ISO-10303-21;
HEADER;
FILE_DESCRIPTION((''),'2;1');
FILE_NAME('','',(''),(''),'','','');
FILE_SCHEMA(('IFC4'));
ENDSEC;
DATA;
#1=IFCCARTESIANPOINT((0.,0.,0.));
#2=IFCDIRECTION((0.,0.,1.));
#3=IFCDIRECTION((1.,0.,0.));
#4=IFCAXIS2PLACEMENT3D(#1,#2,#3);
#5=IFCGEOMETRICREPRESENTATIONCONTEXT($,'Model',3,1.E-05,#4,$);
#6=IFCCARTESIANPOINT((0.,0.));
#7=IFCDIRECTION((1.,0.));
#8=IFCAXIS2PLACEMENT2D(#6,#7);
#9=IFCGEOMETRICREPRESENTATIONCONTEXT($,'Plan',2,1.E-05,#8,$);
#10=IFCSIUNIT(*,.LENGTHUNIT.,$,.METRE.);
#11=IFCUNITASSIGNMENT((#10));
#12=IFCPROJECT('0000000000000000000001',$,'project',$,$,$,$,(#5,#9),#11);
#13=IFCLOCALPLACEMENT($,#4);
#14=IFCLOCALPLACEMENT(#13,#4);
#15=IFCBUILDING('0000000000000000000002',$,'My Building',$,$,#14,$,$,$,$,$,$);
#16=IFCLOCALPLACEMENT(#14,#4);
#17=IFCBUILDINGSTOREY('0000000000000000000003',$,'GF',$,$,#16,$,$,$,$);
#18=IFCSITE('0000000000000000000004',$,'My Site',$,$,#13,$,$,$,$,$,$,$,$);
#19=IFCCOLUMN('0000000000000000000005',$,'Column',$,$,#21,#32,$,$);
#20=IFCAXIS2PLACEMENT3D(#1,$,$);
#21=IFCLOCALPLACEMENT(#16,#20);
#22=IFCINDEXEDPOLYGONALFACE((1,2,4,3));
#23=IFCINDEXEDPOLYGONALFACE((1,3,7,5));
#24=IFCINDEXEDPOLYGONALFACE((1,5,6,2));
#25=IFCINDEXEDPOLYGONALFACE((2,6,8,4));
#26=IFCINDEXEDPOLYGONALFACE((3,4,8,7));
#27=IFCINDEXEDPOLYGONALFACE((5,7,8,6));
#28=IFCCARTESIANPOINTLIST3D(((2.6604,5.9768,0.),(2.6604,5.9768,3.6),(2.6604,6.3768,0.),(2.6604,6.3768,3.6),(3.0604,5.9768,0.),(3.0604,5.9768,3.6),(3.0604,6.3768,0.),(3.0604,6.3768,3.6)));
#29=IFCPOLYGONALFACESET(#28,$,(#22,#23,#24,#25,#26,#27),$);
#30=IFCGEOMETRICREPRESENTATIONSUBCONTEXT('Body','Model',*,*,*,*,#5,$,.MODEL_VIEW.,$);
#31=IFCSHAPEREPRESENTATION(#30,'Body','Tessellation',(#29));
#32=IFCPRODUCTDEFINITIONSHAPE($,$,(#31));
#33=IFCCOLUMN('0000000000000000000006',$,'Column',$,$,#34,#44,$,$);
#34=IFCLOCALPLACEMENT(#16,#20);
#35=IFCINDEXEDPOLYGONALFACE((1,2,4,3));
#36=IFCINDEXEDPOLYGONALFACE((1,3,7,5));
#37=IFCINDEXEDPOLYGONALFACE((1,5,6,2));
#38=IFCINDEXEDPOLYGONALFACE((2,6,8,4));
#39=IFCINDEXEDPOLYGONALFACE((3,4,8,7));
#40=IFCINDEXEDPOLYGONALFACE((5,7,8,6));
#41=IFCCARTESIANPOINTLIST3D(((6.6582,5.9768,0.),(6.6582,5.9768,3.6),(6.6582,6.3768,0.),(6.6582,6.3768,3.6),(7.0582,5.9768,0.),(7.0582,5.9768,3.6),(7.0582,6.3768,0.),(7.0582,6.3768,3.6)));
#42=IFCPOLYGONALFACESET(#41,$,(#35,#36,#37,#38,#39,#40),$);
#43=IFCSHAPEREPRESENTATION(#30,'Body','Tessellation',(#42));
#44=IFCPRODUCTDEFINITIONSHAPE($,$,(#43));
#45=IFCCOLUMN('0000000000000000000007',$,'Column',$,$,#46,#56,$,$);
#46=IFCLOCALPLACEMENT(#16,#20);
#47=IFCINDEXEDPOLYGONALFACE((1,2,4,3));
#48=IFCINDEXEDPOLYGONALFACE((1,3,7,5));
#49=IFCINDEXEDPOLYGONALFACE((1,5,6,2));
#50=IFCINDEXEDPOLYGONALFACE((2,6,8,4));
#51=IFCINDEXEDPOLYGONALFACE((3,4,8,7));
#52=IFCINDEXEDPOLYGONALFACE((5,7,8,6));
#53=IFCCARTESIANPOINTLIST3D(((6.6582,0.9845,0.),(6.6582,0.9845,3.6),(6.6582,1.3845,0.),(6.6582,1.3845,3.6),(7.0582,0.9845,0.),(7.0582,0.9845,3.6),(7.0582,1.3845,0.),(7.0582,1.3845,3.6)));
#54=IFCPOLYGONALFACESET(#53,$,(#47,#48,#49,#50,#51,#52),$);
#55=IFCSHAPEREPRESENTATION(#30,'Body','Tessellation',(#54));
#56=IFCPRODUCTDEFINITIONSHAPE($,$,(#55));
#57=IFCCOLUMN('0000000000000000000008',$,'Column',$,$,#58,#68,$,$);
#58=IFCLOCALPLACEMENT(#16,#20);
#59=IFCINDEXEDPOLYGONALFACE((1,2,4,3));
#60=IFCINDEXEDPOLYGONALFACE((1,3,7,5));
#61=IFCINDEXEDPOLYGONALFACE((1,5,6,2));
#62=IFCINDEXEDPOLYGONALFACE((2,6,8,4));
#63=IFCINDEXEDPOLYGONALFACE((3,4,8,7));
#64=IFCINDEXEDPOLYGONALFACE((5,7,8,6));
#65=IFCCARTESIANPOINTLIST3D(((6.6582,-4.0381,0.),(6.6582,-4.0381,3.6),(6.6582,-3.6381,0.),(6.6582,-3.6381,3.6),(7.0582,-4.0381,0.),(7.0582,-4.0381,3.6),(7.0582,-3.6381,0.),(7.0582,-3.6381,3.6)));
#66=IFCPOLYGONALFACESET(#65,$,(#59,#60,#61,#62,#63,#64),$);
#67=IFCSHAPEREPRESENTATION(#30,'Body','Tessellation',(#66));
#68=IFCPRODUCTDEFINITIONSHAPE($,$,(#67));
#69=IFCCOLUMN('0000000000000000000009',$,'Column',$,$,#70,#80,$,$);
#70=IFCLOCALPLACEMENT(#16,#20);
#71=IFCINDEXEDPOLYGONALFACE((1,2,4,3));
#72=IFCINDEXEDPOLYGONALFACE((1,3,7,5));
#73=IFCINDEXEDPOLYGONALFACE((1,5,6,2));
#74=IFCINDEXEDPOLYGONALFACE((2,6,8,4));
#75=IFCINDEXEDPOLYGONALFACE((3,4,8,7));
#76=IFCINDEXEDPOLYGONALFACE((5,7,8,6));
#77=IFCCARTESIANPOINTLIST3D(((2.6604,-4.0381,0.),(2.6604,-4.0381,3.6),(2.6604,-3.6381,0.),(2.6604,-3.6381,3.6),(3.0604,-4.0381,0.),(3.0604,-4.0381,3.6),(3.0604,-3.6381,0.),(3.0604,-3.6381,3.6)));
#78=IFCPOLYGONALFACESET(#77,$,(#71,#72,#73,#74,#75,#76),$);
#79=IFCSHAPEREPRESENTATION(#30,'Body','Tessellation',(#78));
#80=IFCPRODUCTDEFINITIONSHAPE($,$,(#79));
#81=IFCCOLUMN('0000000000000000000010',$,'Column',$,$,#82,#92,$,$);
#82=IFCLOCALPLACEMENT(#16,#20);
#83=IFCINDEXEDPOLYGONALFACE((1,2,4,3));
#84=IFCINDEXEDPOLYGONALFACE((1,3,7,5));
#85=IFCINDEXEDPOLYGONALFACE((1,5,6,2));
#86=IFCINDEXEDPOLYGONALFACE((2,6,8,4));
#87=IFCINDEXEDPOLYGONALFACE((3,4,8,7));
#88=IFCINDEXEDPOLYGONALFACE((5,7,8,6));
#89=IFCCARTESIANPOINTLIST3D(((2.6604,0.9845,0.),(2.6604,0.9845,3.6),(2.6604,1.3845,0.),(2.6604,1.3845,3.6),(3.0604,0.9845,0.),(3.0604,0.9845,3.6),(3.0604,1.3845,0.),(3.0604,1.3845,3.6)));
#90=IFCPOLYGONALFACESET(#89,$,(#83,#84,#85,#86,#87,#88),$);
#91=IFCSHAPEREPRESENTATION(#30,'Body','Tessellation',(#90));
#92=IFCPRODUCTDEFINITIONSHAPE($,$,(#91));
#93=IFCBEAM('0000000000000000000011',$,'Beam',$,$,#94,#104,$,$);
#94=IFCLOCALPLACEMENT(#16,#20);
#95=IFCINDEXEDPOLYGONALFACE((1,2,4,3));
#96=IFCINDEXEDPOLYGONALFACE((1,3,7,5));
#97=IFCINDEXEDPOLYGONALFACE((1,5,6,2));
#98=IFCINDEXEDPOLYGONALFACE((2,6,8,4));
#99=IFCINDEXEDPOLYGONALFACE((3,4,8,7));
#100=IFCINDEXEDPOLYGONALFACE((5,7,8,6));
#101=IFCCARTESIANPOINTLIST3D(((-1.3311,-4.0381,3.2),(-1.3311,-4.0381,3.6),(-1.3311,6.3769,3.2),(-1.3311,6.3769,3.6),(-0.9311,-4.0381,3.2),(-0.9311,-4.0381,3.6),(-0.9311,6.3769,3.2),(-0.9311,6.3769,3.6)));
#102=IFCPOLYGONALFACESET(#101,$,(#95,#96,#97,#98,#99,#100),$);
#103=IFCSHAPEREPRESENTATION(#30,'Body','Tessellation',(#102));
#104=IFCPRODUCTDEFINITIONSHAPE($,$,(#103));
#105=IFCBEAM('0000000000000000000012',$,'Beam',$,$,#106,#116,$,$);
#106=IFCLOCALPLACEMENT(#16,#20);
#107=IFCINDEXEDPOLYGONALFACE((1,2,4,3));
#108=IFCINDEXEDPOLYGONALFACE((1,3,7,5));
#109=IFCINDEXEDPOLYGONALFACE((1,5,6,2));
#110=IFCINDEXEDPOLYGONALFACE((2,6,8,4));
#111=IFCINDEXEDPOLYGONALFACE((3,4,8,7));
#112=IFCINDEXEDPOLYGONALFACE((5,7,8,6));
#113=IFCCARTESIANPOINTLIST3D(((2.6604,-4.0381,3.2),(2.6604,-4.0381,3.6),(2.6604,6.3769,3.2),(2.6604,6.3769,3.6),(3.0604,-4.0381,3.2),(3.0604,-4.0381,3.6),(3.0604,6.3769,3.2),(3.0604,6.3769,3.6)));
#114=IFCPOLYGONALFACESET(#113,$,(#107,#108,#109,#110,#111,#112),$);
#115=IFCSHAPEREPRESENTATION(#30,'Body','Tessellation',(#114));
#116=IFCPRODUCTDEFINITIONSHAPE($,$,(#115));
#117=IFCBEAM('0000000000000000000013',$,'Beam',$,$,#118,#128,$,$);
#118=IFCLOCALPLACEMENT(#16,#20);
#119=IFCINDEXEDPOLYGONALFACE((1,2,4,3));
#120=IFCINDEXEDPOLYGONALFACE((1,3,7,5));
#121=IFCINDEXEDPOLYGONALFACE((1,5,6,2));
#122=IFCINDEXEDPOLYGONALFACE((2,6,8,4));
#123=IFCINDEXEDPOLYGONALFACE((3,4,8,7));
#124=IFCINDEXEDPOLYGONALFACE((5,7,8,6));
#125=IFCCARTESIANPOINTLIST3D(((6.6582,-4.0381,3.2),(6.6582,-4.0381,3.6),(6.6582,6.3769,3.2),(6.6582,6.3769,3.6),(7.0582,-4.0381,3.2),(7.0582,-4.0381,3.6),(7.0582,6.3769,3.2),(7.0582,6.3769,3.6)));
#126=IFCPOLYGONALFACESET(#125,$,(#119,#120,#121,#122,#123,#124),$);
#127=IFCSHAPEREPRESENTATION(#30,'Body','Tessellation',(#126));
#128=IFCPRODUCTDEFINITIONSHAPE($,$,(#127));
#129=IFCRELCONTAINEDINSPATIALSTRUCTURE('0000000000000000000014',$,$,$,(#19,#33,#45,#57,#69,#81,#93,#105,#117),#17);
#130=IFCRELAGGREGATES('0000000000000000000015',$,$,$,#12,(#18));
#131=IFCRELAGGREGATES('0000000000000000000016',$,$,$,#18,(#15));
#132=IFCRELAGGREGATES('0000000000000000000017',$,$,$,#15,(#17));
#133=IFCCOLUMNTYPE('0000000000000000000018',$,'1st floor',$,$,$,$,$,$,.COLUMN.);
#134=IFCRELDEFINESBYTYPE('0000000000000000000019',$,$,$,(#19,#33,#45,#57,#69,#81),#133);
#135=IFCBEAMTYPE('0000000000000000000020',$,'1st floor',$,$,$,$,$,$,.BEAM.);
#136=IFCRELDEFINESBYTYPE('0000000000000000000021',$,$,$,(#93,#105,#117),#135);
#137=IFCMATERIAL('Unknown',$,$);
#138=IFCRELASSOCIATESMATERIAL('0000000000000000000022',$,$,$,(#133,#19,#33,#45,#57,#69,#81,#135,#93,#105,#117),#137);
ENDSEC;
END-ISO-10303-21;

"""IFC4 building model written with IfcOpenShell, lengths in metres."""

from ifc_helpers import new_model, si_unit, frame, origin_with_axes, origin_2d_with_axis, place, context, subcontext, project, spatial, rectangle, extrude, material, material_profile, profile_set, profile_usage, type_object, element, save


model = new_model("IFC4")

# Units and contexts
model_context = context("Model", 3, precision=1e-05, world=origin_with_axes())
plan_context = context("Plan", 2, precision=1e-05, world=origin_2d_with_axis())
body_context_1 = subcontext(model_context, "Body", "Model", "MODEL_VIEW")
ifc_project = project(units=[si_unit("LENGTHUNIT", "METRE")], contexts=[model_context, plan_context])

# Site, building, storey
site_placement = place(None, origin_with_axes())
site = spatial("IfcSite", under=ifc_project, at=site_placement, Name="My Site")
building_placement = place(site_placement, origin_with_axes())
building = spatial("IfcBuilding", under=site, at=building_placement, Name="My Building")
storey_placement = place(building_placement, origin_with_axes())
storey = spatial("IfcBuildingStorey", under=building, at=storey_placement, Name="GF")

# Columns
ifc_material = material(Name="Unknown")
ifc_material_profile_1 = material_profile(ifc_material, rectangle(XDim=0.4, YDim=0.4))
ifc_profile_set_1 = profile_set([ifc_material_profile_1])
ifc_profile_usage_1 = profile_usage(ifc_profile_set_1, cardinal=5)
column_type = type_object("IfcColumnType", Name="1st floor", PredefinedType="COLUMN", material=ifc_profile_set_1)
column_1_placement = place(storey_placement, frame((2.8604, 6.1768, 0.0), z_axis=(0.0, 0.0, 1.0), x_axis=(1.0, 0.0, 0.0)))
element("IfcColumn", 1, at=column_1_placement, inside=storey, type_object=column_type, material=ifc_profile_usage_1, Name="Column", context=body_context_1, shape_type="SweptSolid", body=[
    extrude(rectangle(XDim=0.4, YDim=0.4), origin_with_axes(), (0.0, 0.0, 1.0), 3.6),
])
ifc_profile_usage_2 = profile_usage(ifc_profile_set_1, cardinal=5)
column_2_placement = place(storey_placement, frame((6.8582, 6.1768, 0.0), z_axis=(0.0, 0.0, 1.0), x_axis=(1.0, 0.0, 0.0)))
element("IfcColumn", 2, at=column_2_placement, inside=storey, type_object=column_type, material=ifc_profile_usage_2, Name="Column", context=body_context_1, shape_type="SweptSolid", body=[
    extrude(rectangle(XDim=0.4, YDim=0.4), origin_with_axes(), (0.0, 0.0, 1.0), 3.6),
])
ifc_profile_usage_3 = profile_usage(ifc_profile_set_1, cardinal=5)
column_3_placement = place(storey_placement, frame((6.8582, 1.1845, 0.0), z_axis=(0.0, 0.0, 1.0), x_axis=(1.0, 0.0, 0.0)))
element("IfcColumn", 3, at=column_3_placement, inside=storey, type_object=column_type, material=ifc_profile_usage_3, Name="Column", context=body_context_1, shape_type="SweptSolid", body=[
    extrude(rectangle(XDim=0.4, YDim=0.4), origin_with_axes(), (0.0, 0.0, 1.0), 3.6),
])
ifc_profile_usage_4 = profile_usage(ifc_profile_set_1, cardinal=5)
column_4_placement = place(storey_placement, frame((6.8582, -3.8381, 0.0), z_axis=(0.0, 0.0, 1.0), x_axis=(1.0, 0.0, 0.0)))
element("IfcColumn", 4, at=column_4_placement, inside=storey, type_object=column_type, material=ifc_profile_usage_4, Name="Column", context=body_context_1, shape_type="SweptSolid", body=[
    extrude(rectangle(XDim=0.4, YDim=0.4), origin_with_axes(), (0.0, 0.0, 1.0), 3.6),
])
ifc_profile_usage_5 = profile_usage(ifc_profile_set_1, cardinal=5)
column_5_placement = place(storey_placement, frame((2.8604, -3.8381, 0.0), z_axis=(0.0, 0.0, 1.0), x_axis=(1.0, 0.0, 0.0)))
element("IfcColumn", 5, at=column_5_placement, inside=storey, type_object=column_type, material=ifc_profile_usage_5, Name="Column", context=body_context_1, shape_type="SweptSolid", body=[
    extrude(rectangle(XDim=0.4, YDim=0.4), origin_with_axes(), (0.0, 0.0, 1.0), 3.6),
])
ifc_profile_usage_6 = profile_usage(ifc_profile_set_1, cardinal=5)
column_6_placement = place(storey_placement, frame((2.8604, 1.1845, 0.0), z_axis=(0.0, 0.0, 1.0), x_axis=(1.0, 0.0, 0.0)))
element("IfcColumn", 6, at=column_6_placement, inside=storey, type_object=column_type, material=ifc_profile_usage_6, Name="Column", context=body_context_1, shape_type="SweptSolid", body=[
    extrude(rectangle(XDim=0.4, YDim=0.4), origin_with_axes(), (0.0, 0.0, 1.0), 3.6),
])

# Beams
ifc_material_profile_2 = material_profile(ifc_material, rectangle(XDim=0.4, YDim=0.4))
ifc_profile_set_2 = profile_set([ifc_material_profile_2])
ifc_profile_usage_7 = profile_usage(ifc_profile_set_2, cardinal=5)
beam_type = type_object("IfcBeamType", Name="1st floor", PredefinedType="BEAM", material=ifc_profile_set_2)
beam_1_placement = place(storey_placement, frame((-1.1311, 6.3769, 3.4), z_axis=(0.0, -1.0, 0.0), x_axis=(1.0, 0.0, 0.0)))
element("IfcBeam", 7, at=beam_1_placement, inside=storey, type_object=beam_type, material=ifc_profile_usage_7, Name="Beam", context=body_context_1, shape_type="SweptSolid", body=[
    extrude(rectangle(XDim=0.4, YDim=0.4), origin_with_axes(), (0.0, 0.0, 1.0), 10.415),
])
ifc_profile_usage_8 = profile_usage(ifc_profile_set_2, cardinal=5)
beam_2_placement = place(storey_placement, frame((2.8604, 6.3769, 3.4), z_axis=(0.0, -1.0, 0.0), x_axis=(1.0, 0.0, 0.0)))
element("IfcBeam", 8, at=beam_2_placement, inside=storey, type_object=beam_type, material=ifc_profile_usage_8, Name="Beam", context=body_context_1, shape_type="SweptSolid", body=[
    extrude(rectangle(XDim=0.4, YDim=0.4), origin_with_axes(), (0.0, 0.0, 1.0), 10.415),
])
ifc_profile_usage_9 = profile_usage(ifc_profile_set_2, cardinal=5)
beam_3_placement = place(storey_placement, frame((6.8582, 6.3769, 3.4), z_axis=(0.0, -1.0, 0.0), x_axis=(1.0, 0.0, 0.0)))
element("IfcBeam", 9, at=beam_3_placement, inside=storey, type_object=beam_type, material=ifc_profile_usage_9, Name="Beam", context=body_context_1, shape_type="SweptSolid", body=[
    extrude(rectangle(XDim=0.4, YDim=0.4), origin_with_axes(), (0.0, 0.0, 1.0), 10.415),
])

save(model, "model.ifc")
